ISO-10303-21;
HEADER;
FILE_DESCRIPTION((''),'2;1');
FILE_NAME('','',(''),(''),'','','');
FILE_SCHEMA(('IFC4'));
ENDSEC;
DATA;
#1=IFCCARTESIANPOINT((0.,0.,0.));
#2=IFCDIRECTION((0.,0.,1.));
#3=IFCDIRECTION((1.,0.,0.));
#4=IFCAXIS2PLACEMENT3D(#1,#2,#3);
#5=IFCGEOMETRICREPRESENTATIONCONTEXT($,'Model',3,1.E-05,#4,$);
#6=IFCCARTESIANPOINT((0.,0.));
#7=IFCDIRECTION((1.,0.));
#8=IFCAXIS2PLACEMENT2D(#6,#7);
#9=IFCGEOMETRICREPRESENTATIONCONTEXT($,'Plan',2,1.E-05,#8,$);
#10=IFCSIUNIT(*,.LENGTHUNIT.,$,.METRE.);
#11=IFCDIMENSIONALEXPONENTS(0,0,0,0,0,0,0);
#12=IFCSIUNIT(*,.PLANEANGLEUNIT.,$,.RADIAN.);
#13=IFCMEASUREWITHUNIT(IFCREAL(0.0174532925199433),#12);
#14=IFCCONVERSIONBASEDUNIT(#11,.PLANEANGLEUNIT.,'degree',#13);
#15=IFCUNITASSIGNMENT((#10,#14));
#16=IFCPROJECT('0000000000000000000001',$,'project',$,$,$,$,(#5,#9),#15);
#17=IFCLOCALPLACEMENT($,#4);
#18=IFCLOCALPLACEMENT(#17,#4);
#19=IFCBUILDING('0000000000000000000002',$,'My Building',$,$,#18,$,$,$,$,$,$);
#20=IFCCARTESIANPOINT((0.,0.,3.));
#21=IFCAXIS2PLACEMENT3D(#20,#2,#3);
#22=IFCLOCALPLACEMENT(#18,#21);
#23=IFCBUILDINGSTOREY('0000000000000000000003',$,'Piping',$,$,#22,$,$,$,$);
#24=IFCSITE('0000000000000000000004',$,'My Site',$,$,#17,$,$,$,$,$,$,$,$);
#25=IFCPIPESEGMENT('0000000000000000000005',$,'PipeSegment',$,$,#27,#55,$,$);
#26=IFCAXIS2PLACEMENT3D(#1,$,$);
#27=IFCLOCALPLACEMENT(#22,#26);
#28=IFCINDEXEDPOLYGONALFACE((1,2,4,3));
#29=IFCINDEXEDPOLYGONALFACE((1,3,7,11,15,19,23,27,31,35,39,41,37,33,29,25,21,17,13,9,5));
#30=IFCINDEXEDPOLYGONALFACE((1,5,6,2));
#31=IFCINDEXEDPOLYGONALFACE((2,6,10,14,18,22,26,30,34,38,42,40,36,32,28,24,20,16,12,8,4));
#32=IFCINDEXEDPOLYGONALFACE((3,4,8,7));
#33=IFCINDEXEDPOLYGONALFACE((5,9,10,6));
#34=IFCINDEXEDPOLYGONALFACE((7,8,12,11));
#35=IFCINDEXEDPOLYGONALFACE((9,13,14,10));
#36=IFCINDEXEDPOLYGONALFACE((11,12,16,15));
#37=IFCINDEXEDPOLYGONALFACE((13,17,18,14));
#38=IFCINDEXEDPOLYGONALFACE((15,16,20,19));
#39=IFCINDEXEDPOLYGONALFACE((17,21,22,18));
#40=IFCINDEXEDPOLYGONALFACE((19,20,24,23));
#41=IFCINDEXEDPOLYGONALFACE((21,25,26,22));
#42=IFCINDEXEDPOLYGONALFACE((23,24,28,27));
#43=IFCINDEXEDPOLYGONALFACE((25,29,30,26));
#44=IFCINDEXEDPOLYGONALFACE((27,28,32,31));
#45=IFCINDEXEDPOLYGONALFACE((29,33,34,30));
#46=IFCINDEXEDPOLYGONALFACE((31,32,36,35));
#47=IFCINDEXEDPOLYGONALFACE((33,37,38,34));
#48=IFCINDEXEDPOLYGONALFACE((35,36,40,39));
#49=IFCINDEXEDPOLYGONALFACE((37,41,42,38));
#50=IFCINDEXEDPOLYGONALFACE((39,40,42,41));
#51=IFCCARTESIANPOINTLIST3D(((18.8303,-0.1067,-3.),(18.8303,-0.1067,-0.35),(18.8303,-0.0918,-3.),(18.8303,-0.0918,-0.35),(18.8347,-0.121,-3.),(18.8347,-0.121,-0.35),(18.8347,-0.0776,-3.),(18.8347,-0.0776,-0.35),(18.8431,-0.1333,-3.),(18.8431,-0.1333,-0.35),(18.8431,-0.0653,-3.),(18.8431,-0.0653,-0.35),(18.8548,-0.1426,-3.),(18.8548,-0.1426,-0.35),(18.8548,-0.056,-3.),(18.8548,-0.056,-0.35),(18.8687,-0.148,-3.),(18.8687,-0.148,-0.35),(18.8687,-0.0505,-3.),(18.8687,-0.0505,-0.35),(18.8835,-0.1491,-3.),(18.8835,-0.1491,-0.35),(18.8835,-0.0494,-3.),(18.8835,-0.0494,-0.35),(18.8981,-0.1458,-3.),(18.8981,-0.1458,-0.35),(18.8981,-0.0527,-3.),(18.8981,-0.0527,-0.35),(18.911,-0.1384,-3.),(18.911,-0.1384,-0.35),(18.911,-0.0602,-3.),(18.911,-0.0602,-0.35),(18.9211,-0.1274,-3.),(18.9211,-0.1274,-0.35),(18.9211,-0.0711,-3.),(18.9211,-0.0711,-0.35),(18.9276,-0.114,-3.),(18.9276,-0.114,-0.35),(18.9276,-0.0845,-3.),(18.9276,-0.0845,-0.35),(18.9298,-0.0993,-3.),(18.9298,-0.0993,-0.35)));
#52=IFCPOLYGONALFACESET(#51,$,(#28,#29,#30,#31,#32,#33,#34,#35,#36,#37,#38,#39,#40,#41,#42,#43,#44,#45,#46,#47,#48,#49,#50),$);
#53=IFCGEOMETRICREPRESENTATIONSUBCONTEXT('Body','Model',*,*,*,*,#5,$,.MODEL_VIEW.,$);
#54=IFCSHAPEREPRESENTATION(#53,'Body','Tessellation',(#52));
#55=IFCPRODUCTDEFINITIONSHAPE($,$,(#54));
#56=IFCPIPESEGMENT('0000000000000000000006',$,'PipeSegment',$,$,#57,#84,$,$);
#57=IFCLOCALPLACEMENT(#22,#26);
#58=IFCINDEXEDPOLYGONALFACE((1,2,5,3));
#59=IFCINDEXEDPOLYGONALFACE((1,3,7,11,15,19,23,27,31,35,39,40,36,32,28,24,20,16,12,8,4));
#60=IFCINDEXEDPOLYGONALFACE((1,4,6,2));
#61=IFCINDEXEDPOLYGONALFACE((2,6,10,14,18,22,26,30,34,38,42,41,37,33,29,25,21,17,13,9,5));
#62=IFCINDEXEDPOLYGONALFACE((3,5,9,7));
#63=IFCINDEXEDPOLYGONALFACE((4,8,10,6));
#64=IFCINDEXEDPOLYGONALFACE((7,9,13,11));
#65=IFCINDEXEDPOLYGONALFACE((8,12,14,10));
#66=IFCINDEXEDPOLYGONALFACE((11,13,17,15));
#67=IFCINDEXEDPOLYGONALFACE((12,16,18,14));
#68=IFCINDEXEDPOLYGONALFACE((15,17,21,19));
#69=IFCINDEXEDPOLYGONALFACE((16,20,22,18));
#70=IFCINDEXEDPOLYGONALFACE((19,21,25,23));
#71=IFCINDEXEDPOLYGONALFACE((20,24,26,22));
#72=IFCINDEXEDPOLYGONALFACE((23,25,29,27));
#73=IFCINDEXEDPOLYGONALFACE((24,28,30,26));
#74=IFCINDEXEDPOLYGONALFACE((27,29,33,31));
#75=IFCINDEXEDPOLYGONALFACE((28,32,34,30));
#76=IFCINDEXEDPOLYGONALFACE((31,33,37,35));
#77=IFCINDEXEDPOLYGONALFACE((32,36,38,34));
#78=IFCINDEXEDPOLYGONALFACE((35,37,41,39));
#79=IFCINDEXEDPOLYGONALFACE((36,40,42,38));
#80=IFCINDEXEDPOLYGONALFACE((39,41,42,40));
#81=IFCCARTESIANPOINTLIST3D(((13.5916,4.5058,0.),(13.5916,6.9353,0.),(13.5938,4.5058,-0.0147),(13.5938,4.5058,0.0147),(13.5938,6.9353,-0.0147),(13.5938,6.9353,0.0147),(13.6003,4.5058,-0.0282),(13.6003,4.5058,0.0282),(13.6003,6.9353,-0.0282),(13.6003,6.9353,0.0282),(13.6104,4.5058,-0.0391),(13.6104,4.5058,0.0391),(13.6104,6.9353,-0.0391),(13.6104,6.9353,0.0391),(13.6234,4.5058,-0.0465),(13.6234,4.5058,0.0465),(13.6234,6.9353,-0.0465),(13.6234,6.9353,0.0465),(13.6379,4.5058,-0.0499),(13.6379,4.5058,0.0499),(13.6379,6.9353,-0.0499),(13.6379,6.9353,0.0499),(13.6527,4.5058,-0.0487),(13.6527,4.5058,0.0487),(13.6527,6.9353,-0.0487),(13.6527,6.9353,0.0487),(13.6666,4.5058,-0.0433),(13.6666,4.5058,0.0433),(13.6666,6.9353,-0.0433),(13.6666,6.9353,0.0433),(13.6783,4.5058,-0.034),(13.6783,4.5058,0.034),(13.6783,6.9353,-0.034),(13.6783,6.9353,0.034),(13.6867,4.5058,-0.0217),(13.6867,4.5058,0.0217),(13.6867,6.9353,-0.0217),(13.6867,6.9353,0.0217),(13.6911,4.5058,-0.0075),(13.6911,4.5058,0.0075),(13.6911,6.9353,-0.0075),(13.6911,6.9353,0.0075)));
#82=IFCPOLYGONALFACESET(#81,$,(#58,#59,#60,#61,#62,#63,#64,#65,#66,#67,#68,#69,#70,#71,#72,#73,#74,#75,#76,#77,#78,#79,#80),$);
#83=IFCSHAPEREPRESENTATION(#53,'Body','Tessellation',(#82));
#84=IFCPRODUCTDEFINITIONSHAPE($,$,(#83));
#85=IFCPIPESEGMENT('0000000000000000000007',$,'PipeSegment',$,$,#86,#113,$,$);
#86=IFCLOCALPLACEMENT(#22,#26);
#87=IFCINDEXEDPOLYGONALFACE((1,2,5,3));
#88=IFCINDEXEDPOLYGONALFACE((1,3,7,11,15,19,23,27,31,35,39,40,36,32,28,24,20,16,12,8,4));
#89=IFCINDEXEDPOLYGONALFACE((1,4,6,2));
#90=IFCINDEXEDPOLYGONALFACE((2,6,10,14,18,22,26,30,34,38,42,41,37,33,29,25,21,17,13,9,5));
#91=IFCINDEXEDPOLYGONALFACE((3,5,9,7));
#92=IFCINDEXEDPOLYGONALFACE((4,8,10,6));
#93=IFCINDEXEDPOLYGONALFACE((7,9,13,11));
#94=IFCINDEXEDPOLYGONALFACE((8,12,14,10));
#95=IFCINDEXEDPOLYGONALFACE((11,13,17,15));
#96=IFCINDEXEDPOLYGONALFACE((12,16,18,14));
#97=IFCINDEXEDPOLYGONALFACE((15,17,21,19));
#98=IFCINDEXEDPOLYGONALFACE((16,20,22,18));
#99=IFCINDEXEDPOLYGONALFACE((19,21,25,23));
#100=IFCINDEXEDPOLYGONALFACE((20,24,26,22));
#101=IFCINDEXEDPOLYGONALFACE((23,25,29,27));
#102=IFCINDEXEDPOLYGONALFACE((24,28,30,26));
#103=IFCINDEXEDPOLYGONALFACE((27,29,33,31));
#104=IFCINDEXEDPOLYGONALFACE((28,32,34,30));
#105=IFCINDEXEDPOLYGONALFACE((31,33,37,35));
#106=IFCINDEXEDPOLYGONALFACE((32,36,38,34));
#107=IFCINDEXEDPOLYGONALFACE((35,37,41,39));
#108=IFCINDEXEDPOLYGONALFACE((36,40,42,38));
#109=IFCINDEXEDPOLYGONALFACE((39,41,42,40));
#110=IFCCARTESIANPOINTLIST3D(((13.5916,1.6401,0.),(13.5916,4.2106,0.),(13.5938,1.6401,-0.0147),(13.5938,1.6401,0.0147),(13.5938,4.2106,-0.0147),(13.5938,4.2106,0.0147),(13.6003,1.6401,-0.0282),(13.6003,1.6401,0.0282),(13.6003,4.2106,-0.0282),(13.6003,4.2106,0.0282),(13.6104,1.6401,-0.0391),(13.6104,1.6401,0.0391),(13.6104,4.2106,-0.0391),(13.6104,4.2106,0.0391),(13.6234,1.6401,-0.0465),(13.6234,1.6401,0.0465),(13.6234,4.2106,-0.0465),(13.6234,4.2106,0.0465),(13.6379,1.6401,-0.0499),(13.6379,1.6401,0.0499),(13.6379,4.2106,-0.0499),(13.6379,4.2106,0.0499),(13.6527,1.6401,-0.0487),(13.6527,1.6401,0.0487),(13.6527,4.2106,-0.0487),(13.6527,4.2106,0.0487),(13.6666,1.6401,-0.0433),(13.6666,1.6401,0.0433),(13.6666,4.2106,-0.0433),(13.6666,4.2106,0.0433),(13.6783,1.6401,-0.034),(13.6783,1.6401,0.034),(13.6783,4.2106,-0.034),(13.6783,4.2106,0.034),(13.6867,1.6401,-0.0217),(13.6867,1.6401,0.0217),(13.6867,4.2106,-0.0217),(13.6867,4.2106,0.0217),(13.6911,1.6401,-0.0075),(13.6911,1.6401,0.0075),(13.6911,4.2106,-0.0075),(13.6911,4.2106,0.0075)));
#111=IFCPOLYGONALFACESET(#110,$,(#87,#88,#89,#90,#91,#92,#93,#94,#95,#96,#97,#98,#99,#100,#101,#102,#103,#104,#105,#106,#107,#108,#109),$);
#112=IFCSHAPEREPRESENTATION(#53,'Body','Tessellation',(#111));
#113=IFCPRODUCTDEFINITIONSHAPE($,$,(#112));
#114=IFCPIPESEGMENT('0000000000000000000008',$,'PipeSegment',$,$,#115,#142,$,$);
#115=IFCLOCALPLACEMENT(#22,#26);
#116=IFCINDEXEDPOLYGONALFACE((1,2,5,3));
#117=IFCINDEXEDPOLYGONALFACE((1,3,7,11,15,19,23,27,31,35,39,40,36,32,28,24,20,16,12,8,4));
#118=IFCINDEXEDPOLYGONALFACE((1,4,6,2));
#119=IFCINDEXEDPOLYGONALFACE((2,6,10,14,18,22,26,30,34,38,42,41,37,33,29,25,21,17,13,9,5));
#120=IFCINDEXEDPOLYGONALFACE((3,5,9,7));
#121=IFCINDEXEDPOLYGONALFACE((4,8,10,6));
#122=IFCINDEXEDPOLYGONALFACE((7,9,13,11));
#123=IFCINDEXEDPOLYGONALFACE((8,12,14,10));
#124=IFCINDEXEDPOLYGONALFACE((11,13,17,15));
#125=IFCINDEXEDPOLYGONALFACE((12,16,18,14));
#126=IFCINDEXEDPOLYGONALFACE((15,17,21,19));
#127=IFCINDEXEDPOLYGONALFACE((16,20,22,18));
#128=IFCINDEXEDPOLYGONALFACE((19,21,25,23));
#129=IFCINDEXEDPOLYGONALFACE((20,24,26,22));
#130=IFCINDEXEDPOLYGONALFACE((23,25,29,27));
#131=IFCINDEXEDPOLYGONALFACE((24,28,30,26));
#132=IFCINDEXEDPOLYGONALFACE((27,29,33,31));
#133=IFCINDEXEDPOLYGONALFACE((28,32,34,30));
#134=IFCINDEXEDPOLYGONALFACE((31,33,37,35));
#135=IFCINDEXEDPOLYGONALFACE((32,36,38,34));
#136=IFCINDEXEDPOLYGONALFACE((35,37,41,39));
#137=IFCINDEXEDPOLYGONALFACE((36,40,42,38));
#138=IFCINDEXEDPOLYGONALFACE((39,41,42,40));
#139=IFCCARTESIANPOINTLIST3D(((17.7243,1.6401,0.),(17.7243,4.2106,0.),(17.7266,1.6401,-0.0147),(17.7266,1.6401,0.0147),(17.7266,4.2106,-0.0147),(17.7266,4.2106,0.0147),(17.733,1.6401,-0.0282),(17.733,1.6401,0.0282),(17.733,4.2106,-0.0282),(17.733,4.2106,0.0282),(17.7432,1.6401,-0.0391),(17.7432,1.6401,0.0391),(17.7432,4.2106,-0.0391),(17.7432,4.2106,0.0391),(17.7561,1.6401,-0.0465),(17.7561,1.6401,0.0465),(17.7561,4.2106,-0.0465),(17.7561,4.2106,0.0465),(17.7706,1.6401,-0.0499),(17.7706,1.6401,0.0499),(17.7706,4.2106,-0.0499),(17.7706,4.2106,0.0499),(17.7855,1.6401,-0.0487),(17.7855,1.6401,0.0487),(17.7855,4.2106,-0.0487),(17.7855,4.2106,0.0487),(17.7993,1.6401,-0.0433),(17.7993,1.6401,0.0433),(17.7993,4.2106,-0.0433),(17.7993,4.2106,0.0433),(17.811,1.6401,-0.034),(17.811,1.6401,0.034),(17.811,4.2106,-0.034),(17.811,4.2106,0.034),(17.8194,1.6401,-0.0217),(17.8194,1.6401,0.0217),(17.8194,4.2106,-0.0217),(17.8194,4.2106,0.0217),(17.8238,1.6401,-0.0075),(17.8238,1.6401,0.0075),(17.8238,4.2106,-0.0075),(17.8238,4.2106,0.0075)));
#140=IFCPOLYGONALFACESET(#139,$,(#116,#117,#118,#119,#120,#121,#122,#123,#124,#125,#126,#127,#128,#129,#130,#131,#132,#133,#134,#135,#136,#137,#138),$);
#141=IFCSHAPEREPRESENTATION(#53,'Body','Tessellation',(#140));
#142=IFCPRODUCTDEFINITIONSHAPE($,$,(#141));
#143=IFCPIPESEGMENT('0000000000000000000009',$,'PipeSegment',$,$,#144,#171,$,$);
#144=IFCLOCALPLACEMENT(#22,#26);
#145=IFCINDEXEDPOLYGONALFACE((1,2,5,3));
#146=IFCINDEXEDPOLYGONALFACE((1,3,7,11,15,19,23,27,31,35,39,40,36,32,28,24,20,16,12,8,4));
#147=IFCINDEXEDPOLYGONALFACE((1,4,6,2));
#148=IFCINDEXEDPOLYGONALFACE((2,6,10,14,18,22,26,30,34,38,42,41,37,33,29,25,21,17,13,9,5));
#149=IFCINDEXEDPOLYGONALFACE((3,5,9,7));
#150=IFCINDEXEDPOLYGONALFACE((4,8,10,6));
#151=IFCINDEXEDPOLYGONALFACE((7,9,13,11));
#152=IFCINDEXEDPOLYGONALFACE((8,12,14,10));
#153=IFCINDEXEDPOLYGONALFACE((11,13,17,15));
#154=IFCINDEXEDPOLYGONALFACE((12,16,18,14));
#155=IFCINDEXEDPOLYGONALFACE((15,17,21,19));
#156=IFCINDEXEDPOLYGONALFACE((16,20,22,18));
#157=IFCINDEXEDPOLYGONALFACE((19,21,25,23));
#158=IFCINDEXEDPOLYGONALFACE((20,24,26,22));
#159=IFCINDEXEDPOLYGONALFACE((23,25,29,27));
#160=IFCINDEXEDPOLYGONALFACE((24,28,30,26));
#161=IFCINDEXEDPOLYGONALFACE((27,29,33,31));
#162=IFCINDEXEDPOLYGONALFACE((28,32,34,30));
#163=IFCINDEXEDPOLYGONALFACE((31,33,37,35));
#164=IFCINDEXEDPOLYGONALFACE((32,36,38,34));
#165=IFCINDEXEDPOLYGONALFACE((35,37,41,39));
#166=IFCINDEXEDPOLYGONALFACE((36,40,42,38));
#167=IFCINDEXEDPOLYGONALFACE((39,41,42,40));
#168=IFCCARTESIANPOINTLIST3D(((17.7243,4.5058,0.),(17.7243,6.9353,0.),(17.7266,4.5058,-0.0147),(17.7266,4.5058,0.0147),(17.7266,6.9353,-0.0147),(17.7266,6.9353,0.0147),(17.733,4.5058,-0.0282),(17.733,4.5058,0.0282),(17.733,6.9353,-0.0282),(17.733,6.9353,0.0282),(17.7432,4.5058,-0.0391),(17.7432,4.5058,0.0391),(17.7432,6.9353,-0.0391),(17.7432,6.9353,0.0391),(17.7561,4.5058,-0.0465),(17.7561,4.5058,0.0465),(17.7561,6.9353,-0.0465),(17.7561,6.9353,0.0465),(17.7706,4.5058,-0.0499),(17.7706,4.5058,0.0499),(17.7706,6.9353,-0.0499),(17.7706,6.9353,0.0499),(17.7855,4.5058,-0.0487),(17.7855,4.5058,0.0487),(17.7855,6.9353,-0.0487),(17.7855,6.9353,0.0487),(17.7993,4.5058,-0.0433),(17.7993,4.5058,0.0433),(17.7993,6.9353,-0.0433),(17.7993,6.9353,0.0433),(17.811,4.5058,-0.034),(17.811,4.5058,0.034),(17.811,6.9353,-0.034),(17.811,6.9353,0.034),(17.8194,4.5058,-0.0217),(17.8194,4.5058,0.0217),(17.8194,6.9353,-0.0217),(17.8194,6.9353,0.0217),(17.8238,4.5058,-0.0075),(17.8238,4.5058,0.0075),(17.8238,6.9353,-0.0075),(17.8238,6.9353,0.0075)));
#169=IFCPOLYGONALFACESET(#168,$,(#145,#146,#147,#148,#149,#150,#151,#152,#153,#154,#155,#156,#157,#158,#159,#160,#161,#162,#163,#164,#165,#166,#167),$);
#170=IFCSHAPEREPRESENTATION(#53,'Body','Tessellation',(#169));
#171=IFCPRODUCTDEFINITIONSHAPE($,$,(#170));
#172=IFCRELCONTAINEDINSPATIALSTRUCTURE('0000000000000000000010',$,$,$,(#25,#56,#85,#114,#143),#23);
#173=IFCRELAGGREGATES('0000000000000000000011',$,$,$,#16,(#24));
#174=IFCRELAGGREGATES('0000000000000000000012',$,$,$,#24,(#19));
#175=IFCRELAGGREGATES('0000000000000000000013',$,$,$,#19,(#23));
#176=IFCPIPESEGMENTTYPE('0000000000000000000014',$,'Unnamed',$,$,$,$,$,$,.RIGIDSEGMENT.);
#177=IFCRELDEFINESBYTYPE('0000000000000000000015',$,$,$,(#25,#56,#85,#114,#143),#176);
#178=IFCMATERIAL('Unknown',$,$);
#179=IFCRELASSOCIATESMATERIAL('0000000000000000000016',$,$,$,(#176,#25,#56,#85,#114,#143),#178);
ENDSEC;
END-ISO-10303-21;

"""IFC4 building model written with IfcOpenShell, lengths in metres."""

from ifc_helpers import new_model, entity, si_unit, converted_unit, frame, origin_with_axes, origin_2d_with_axis, place, context, subcontext, project, spatial, circle, extrude, material, material_profile, profile_set, profile_usage, type_object, element, save


model = new_model("IFC4")

# Units and contexts
model_context = context("Model", 3, precision=1e-05, world=origin_with_axes())
plan_context = context("Plan", 2, precision=1e-05, world=origin_2d_with_axis())
body_context = subcontext(model_context, "Body", "Model", "MODEL_VIEW")
ifc_project = project(units=[si_unit("LENGTHUNIT", "METRE"), converted_unit("PLANEANGLEUNIT", "degree", entity("IfcReal", 0.0174532925199433), si_unit("PLANEANGLEUNIT", "RADIAN"), dimensions=[0, 0, 0, 0, 0, 0, 0])], contexts=[model_context, plan_context])

# Site, building, storey
site_placement = place(None, origin_with_axes())
site = spatial("IfcSite", under=ifc_project, at=site_placement, Name="My Site")
building_placement = place(site_placement, origin_with_axes())
building = spatial("IfcBuilding", under=site, at=building_placement, Name="My Building")
storey_placement = place(building_placement, frame((0.0, 0.0, 3.0), z_axis=(0.0, 0.0, 1.0), x_axis=(1.0, 0.0, 0.0)))
storey = spatial("IfcBuildingStorey", under=building, at=storey_placement, Name="Piping")

# Pipe segments
ifc_material = material(Name="Unknown")
ifc_material_profile_1 = material_profile(ifc_material, circle(Radius=0.05))
ifc_profile_set_1 = profile_set([ifc_material_profile_1])
pipe_segment_type = type_object("IfcPipeSegmentType", Name="Unnamed", PredefinedType="RIGIDSEGMENT", material=ifc_profile_set_1)
ifc_profile_usage_1 = profile_usage(ifc_profile_set_1, cardinal=5)
pipe_segment_1_placement = place(storey_placement, frame((18.8798, -0.0993, -0.35), z_axis=(0.0, 0.0, -1.0), x_axis=(1.0, 0.0, 0.0)))
element("IfcPipeSegment", 1, at=pipe_segment_1_placement, inside=storey, type_object=pipe_segment_type, material=ifc_profile_usage_1, Name="PipeSegment", context=body_context, shape_type="SweptSolid", body=[
    extrude(circle(Radius=0.05), origin_with_axes(), (0.0, 0.0, 1.0), 2.65),
])
ifc_profile_usage_2 = profile_usage(ifc_profile_set_1, cardinal=5)
pipe_segment_2_placement = place(storey_placement, frame((13.6416, 6.9353, 0.0), z_axis=(0.0, -1.0, 0.0), x_axis=(-1.0, 0.0, 0.0)))
element("IfcPipeSegment", 2, at=pipe_segment_2_placement, inside=storey, type_object=pipe_segment_type, material=ifc_profile_usage_2, Name="PipeSegment", context=body_context, shape_type="SweptSolid", body=[
    extrude(circle(Radius=0.05), origin_with_axes(), (0.0, 0.0, 1.0), 2.4294),
])
ifc_profile_usage_3 = profile_usage(ifc_profile_set_1, cardinal=5)
pipe_segment_3_placement = place(storey_placement, frame((13.6416, 4.2106, 0.0), z_axis=(0.0, -1.0, 0.0), x_axis=(-1.0, 0.0, 0.0)))
element("IfcPipeSegment", 3, at=pipe_segment_3_placement, inside=storey, type_object=pipe_segment_type, material=ifc_profile_usage_3, Name="PipeSegment", context=body_context, shape_type="SweptSolid", body=[
    extrude(circle(Radius=0.05), origin_with_axes(), (0.0, 0.0, 1.0), 2.5705),
])
ifc_profile_usage_4 = profile_usage(ifc_profile_set_1, cardinal=5)
pipe_segment_4_placement = place(storey_placement, frame((17.7743, 4.2106, 0.0), z_axis=(0.0, -1.0, 0.0), x_axis=(-1.0, 0.0, 0.0)))
element("IfcPipeSegment", 4, at=pipe_segment_4_placement, inside=storey, type_object=pipe_segment_type, material=ifc_profile_usage_4, Name="PipeSegment", context=body_context, shape_type="SweptSolid", body=[
    extrude(circle(Radius=0.05), origin_with_axes(), (0.0, 0.0, 1.0), 2.5705),
])
ifc_profile_usage_5 = profile_usage(ifc_profile_set_1, cardinal=5)
pipe_segment_5_placement = place(storey_placement, frame((17.7743, 6.9353, 0.0), z_axis=(0.0, -1.0, 0.0), x_axis=(-1.0, 0.0, 0.0)))
element("IfcPipeSegment", 5, at=pipe_segment_5_placement, inside=storey, type_object=pipe_segment_type, material=ifc_profile_usage_5, Name="PipeSegment", context=body_context, shape_type="SweptSolid", body=[
    extrude(circle(Radius=0.05), origin_with_axes(), (0.0, 0.0, 1.0), 2.4294),
])

save(model, "model.ifc")
